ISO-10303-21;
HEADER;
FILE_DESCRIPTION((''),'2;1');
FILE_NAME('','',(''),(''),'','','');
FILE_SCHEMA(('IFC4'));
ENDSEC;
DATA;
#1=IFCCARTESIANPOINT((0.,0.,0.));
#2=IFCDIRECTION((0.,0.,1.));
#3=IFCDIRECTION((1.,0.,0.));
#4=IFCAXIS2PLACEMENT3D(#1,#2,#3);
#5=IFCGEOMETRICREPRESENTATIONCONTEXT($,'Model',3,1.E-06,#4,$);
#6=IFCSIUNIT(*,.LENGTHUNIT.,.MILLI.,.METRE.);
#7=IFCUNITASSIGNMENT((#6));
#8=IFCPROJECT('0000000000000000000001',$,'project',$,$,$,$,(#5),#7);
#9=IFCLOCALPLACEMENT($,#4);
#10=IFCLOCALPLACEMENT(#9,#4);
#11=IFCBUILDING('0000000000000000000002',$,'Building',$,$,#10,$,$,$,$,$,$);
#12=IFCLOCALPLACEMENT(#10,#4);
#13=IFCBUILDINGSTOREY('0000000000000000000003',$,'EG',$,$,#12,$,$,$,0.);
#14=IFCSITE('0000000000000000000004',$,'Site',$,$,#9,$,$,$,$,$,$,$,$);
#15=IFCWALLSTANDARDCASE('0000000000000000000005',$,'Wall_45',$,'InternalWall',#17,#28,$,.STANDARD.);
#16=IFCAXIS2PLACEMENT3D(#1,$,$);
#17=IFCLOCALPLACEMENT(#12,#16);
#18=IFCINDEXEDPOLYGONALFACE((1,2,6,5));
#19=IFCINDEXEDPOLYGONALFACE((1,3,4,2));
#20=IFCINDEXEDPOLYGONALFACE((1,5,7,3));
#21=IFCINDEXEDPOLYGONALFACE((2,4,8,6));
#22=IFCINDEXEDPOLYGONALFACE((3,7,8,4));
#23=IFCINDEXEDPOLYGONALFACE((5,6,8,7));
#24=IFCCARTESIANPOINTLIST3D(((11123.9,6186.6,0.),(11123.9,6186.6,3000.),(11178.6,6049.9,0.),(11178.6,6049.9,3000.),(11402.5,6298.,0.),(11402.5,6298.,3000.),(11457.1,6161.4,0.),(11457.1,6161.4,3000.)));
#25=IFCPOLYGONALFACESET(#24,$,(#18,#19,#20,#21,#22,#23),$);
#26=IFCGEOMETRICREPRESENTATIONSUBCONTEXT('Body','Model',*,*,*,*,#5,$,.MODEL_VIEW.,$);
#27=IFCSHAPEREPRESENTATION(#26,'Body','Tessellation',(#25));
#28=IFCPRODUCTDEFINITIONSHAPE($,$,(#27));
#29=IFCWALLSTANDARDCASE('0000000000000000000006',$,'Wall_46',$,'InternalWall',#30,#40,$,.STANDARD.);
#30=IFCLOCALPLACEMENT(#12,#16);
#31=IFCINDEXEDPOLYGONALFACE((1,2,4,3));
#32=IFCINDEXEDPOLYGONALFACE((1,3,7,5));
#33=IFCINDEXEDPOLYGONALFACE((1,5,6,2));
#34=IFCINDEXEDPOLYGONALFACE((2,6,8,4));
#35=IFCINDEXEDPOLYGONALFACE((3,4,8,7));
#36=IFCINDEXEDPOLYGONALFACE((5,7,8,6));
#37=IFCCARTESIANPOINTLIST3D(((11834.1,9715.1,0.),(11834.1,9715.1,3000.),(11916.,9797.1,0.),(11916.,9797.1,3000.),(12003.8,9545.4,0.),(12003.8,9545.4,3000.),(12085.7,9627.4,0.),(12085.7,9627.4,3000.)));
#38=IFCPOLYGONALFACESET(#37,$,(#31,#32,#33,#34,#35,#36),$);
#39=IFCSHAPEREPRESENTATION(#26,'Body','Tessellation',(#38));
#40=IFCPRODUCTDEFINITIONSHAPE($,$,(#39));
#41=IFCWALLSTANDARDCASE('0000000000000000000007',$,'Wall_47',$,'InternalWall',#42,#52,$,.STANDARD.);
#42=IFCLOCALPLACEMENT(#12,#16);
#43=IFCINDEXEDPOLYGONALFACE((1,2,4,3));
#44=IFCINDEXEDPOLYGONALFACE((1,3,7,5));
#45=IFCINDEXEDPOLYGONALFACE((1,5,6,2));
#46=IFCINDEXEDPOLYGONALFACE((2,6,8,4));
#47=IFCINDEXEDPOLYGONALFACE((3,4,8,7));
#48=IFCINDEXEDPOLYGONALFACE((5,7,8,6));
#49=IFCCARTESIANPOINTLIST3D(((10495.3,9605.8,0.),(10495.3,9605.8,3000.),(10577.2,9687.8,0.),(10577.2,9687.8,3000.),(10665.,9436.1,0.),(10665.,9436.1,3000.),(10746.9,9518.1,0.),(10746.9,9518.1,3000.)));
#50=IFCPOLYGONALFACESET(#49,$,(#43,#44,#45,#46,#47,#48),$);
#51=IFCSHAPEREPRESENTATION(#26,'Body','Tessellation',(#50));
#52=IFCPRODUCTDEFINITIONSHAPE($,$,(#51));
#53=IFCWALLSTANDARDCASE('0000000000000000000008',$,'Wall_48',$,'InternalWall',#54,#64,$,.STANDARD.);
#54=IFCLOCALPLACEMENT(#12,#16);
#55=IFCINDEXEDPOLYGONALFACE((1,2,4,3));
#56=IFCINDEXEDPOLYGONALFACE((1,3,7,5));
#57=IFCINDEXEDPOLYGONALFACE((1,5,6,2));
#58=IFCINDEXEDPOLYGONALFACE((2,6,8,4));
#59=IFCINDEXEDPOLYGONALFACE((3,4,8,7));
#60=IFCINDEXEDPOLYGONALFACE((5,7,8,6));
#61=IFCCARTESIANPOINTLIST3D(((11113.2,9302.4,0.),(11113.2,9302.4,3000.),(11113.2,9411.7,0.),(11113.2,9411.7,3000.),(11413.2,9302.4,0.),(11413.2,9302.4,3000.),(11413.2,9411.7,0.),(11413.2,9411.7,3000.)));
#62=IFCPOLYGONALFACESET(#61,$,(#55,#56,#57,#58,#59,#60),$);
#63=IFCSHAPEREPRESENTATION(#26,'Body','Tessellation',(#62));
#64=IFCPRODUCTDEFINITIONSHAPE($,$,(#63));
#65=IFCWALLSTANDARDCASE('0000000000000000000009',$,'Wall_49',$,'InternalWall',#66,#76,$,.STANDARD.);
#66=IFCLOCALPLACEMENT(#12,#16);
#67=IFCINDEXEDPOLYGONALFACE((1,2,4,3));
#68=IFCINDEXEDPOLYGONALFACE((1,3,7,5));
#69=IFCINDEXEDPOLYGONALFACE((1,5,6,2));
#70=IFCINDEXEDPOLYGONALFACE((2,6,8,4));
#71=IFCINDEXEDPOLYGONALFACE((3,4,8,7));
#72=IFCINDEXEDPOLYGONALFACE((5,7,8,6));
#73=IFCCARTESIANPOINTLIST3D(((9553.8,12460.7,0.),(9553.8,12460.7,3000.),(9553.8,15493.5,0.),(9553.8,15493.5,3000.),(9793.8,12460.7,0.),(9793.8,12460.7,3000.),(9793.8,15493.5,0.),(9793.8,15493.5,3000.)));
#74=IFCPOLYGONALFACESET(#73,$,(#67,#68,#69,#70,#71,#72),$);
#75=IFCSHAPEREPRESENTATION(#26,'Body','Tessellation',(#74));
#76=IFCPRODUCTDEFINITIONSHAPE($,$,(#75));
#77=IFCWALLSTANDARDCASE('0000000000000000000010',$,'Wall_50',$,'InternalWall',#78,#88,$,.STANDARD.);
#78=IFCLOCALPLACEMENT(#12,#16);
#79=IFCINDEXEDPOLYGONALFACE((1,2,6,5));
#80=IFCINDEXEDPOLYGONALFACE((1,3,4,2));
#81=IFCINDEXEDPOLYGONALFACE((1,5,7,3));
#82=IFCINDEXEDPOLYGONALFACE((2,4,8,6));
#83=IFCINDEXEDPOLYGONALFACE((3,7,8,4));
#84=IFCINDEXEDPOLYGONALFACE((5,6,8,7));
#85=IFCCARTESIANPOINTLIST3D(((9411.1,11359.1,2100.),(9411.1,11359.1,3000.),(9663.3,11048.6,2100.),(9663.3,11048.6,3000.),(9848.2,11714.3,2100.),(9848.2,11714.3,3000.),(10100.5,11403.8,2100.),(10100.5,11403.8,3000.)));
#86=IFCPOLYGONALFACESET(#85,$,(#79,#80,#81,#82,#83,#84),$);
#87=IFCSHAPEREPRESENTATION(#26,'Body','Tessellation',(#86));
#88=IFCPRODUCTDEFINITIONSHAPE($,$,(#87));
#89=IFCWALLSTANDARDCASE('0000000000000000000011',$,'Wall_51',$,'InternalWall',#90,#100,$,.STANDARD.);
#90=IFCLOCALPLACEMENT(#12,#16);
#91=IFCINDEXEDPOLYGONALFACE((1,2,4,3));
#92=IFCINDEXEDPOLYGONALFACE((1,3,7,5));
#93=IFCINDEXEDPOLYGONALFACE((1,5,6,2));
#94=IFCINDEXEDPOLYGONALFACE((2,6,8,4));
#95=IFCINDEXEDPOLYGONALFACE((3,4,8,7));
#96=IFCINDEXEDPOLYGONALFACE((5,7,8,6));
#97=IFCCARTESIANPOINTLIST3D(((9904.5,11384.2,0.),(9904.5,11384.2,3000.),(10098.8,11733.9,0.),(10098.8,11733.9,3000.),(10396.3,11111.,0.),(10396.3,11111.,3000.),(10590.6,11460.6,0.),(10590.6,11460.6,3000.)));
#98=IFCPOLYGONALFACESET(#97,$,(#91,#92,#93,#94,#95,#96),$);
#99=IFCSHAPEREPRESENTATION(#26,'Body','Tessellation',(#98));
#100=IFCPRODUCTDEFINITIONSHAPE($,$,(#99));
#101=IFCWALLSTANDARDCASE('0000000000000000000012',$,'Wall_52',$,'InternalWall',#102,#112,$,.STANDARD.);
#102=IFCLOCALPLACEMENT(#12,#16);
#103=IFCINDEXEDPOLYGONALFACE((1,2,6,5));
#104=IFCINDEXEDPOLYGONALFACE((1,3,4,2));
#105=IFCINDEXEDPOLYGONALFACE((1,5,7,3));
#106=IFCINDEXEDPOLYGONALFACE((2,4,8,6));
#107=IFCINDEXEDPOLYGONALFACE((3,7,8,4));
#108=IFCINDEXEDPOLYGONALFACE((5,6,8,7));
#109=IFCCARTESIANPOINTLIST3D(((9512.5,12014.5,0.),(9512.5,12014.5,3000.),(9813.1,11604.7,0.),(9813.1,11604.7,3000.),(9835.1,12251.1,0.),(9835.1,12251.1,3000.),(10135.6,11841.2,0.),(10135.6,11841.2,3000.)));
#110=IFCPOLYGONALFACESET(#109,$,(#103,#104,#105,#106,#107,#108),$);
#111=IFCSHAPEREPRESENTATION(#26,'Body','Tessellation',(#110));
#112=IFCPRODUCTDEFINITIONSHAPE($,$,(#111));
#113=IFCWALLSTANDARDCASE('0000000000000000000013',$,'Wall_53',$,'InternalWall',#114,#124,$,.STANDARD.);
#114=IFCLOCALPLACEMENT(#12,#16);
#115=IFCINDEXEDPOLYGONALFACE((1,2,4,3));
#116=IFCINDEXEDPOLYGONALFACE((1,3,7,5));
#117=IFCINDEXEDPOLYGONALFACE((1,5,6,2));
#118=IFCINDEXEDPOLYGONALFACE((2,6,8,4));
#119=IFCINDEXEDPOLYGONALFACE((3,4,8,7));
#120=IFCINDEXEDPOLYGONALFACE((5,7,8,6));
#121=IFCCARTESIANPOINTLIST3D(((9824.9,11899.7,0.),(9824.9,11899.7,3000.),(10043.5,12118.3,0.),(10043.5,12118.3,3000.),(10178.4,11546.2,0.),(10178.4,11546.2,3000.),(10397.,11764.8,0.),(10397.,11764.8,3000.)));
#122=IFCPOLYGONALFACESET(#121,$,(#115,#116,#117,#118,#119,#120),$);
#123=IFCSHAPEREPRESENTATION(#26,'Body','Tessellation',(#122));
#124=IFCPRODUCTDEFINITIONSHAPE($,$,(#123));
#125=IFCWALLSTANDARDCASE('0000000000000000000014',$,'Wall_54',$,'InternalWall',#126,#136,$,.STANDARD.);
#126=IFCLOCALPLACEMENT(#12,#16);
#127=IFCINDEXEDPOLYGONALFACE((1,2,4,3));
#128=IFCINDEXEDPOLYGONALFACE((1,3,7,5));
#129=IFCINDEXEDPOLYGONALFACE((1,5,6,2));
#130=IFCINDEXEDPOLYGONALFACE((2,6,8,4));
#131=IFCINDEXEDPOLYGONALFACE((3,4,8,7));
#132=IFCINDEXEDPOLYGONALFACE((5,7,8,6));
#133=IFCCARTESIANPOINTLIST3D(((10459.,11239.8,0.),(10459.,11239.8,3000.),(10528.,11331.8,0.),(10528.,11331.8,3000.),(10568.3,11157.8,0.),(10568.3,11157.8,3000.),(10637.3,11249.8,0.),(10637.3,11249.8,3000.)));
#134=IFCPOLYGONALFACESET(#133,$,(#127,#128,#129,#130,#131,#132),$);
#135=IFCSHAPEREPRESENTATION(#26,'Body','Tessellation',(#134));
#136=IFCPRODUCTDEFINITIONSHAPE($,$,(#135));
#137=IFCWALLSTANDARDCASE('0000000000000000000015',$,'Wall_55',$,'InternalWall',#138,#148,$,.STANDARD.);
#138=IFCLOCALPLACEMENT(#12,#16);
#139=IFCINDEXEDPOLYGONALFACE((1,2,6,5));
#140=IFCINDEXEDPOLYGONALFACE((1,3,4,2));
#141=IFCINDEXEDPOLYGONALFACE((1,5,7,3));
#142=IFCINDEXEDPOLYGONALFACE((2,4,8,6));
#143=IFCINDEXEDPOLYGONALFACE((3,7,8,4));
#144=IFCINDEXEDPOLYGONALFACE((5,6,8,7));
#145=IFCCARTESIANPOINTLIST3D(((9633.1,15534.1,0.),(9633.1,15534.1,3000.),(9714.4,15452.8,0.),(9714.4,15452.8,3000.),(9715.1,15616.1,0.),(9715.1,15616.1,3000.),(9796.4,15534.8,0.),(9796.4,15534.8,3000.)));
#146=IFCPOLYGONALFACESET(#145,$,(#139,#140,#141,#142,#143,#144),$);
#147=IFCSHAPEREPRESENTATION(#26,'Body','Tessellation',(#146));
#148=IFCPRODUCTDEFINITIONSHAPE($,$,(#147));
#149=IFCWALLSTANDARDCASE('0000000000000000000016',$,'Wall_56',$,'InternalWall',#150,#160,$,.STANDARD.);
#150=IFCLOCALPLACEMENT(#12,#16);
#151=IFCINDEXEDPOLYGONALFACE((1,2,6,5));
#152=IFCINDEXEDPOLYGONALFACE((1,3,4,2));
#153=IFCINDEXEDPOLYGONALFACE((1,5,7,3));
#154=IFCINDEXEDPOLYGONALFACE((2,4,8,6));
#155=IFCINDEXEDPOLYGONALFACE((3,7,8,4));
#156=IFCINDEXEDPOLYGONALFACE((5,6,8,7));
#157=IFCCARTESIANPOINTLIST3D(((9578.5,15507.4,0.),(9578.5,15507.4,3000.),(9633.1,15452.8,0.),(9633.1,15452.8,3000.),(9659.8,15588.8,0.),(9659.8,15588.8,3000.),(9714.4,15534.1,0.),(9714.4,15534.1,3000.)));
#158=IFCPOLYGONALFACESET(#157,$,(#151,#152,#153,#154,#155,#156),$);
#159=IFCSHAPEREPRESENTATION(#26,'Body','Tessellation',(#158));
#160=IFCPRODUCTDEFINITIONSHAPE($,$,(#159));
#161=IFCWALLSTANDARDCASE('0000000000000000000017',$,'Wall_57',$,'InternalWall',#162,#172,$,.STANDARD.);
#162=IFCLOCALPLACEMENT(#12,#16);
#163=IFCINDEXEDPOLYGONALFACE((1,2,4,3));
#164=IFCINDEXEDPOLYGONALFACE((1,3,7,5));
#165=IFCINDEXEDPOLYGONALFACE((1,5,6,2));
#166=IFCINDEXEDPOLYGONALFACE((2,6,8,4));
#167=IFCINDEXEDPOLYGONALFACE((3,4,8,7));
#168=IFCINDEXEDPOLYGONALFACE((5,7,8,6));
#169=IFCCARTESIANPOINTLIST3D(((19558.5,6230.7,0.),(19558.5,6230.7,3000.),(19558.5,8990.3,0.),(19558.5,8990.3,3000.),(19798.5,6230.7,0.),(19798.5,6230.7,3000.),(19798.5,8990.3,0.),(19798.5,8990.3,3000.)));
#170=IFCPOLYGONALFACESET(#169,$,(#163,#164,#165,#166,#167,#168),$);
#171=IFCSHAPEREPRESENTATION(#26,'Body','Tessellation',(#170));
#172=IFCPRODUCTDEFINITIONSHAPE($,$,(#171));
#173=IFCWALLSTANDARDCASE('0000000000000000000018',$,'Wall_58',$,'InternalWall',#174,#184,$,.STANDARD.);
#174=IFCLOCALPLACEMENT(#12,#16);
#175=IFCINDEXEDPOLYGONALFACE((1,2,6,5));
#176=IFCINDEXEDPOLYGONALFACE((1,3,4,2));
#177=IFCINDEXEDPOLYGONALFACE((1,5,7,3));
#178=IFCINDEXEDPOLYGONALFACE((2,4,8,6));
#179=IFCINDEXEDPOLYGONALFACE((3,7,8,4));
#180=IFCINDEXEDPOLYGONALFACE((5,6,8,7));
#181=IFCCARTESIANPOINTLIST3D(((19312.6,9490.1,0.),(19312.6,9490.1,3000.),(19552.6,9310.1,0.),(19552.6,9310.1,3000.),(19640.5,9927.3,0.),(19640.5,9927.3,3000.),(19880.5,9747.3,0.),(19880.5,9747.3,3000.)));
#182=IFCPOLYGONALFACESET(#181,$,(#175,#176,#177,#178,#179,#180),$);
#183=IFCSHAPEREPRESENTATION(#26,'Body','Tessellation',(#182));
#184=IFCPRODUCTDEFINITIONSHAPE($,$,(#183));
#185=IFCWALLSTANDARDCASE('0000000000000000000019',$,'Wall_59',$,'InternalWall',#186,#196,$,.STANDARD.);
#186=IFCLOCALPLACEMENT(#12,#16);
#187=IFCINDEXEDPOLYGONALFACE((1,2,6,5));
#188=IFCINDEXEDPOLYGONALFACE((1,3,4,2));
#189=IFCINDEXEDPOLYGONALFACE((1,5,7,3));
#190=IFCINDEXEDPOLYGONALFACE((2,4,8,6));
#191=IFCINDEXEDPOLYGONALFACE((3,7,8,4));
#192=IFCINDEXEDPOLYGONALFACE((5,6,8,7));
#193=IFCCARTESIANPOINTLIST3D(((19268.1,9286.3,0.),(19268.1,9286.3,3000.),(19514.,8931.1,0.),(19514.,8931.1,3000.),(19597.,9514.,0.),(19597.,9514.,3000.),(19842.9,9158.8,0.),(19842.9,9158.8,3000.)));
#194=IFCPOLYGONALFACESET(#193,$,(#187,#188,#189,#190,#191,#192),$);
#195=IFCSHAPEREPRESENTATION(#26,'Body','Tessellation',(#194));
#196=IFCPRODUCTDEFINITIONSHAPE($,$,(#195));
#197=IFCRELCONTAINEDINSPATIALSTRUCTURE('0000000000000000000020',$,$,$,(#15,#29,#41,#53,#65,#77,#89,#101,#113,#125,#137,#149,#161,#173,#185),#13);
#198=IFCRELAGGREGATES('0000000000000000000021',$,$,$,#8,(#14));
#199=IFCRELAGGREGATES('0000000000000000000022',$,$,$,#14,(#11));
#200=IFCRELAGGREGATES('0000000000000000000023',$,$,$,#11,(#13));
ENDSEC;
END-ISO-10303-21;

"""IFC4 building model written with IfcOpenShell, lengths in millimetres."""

from ifc_helpers import new_model, si_unit, frame, origin_with_axes, place, context, subcontext, project, spatial, rectangle, extrude, element, save


model = new_model("IFC4")

# Units and contexts
model_context = context("Model", 3, precision=1e-06, world=origin_with_axes())
body_context = subcontext(model_context, "Body", "Model", "MODEL_VIEW")
ifc_project = project(units=[si_unit("LENGTHUNIT", "METRE", prefix="MILLI")], contexts=[model_context])

# Site, building, storey
site_placement = place(None, origin_with_axes())
site = spatial("IfcSite", under=ifc_project, at=site_placement, Name="Site")
building_placement = place(site_placement, origin_with_axes())
building = spatial("IfcBuilding", under=site, at=building_placement, Name="Building")
storey_placement = place(building_placement, origin_with_axes())
storey = spatial("IfcBuildingStorey", under=building, at=storey_placement, Name="EG", Elevation=0.0)

# Walls
wall_1_placement = place(storey_placement, origin_with_axes())
element("IfcWallStandardCase", 1, at=wall_1_placement, inside=storey, Name="Wall_45", ObjectType="InternalWall", PredefinedType="STANDARD", context=body_context, shape_type="SweptSolid", body=[
    extrude(rectangle(XDim=147.1, YDim=300.0), frame((11290.5, 6174.0, 0.0), z_axis=(0.0, 0.0, 1.0), x_axis=(-0.371391, 0.928477, 0.0)), (0.0, 0.0, 1.0), 3000.0),
])
wall_2_placement = place(storey_placement, origin_with_axes())
element("IfcWallStandardCase", 2, at=wall_2_placement, inside=storey, Name="Wall_46", ObjectType="InternalWall", PredefinedType="STANDARD", context=body_context, shape_type="SweptSolid", body=[
    extrude(rectangle(XDim=115.9, YDim=240.0), frame((11959.9, 9671.2, 0.0), z_axis=(0.0, 0.0, 1.0), x_axis=(0.707107, 0.707107, 0.0)), (0.0, 0.0, 1.0), 3000.0),
])
wall_3_placement = place(storey_placement, origin_with_axes())
element("IfcWallStandardCase", 3, at=wall_3_placement, inside=storey, Name="Wall_47", ObjectType="InternalWall", PredefinedType="STANDARD", context=body_context, shape_type="SweptSolid", body=[
    extrude(rectangle(XDim=115.9, YDim=240.0), frame((10621.1, 9561.9, 0.0), z_axis=(0.0, 0.0, 1.0), x_axis=(-0.707107, -0.707107, 0.0)), (0.0, 0.0, 1.0), 3000.0),
])
wall_4_placement = place(storey_placement, origin_with_axes())
element("IfcWallStandardCase", 4, at=wall_4_placement, inside=storey, Name="Wall_48", ObjectType="InternalWall", PredefinedType="STANDARD", context=body_context, shape_type="SweptSolid", body=[
    extrude(rectangle(XDim=109.3, YDim=300.0), frame((11263.2, 9357.0, 0.0), z_axis=(0.0, 0.0, 1.0), x_axis=(0.0, 1.0, 0.0)), (0.0, 0.0, 1.0), 3000.0),
])
wall_5_placement = place(storey_placement, origin_with_axes())
element("IfcWallStandardCase", 5, at=wall_5_placement, inside=storey, Name="Wall_49", ObjectType="InternalWall", PredefinedType="STANDARD", context=body_context, shape_type="SweptSolid", body=[
    extrude(rectangle(XDim=3032.8, YDim=240.0), frame((9673.8, 13977.1, 0.0), z_axis=(0.0, 0.0, 1.0), x_axis=(0.0, 1.0, 0.0)), (0.0, 0.0, 1.0), 3000.0),
])

# Wall, opening
wall_6_placement = place(storey_placement, origin_with_axes())
wall_6 = element("IfcWallStandardCase", 6, at=wall_6_placement, inside=storey, Name="Wall_50", ObjectType="InternalWall", PredefinedType="STANDARD", context=body_context, shape_type="SweptSolid", body=[
    extrude(rectangle(XDim=563.3, YDim=400.0), frame((9755.8, 11381.4, 0.0), z_axis=(0.0, 0.0, 1.0), x_axis=(-0.776114, -0.630593, 0.0)), (0.0, 0.0, 1.0), 3000.0),
])
opening_1_placement = place(wall_6_placement, origin_with_axes())
element("IfcOpeningElement", 7, at=opening_1_placement, inside=storey, cuts=wall_6, context=body_context, shape_type="SweptSolid", body=[
    extrude(rectangle(XDim=1320.1, YDim=400.0), frame((9528.3, 11196.6, 0.0), z_axis=(0.0, 0.0, 1.0), x_axis=(-0.776114, -0.630593, 0.0)), (0.0, 0.0, 1.0), 2100.0),
])

# Walls
wall_7_placement = place(storey_placement, origin_with_axes())
element("IfcWallStandardCase", 8, at=wall_7_placement, inside=storey, Name="Wall_51", ObjectType="InternalWall", PredefinedType="STANDARD", context=body_context, shape_type="SweptSolid", body=[
    extrude(rectangle(XDim=562.6, YDim=400.0), frame((10247.6, 11422.4, 0.0), z_axis=(0.0, 0.0, 1.0), x_axis=(0.874157, -0.485643, 0.0)), (0.0, 0.0, 1.0), 3000.0),
])
wall_8_placement = place(storey_placement, origin_with_axes())
element("IfcWallStandardCase", 9, at=wall_8_placement, inside=storey, Name="Wall_52", ObjectType="InternalWall", PredefinedType="STANDARD", context=body_context, shape_type="SweptSolid", body=[
    extrude(rectangle(XDim=508.2, YDim=400.0), frame((9824.1, 11927.9, 0.0), z_axis=(0.0, 0.0, 1.0), x_axis=(-0.591364, 0.806405, 0.0)), (0.0, 0.0, 1.0), 3000.0),
])
wall_9_placement = place(storey_placement, origin_with_axes())
element("IfcWallStandardCase", 10, at=wall_9_placement, inside=storey, Name="Wall_53", ObjectType="InternalWall", PredefinedType="STANDARD", context=body_context, shape_type="SweptSolid", body=[
    extrude(rectangle(XDim=309.1, YDim=500.0), frame((10110.9, 11832.3, 0.0), z_axis=(0.0, 0.0, 1.0), x_axis=(0.707107, 0.707107, 0.0)), (0.0, 0.0, 1.0), 3000.0),
])
wall_10_placement = place(storey_placement, origin_with_axes())
element("IfcWallStandardCase", 11, at=wall_10_placement, inside=storey, Name="Wall_54", ObjectType="InternalWall", PredefinedType="STANDARD", context=body_context, shape_type="SweptSolid", body=[
    extrude(rectangle(XDim=136.6, YDim=115.0), frame((10548.1, 11244.8, 0.0), z_axis=(0.0, 0.0, 1.0), x_axis=(0.8, -0.6, 0.0)), (0.0, 0.0, 1.0), 3000.0),
])
wall_11_placement = place(storey_placement, origin_with_axes())
element("IfcWallStandardCase", 12, at=wall_11_placement, inside=storey, Name="Wall_55", ObjectType="InternalWall", PredefinedType="STANDARD", context=body_context, shape_type="SweptSolid", body=[
    extrude(rectangle(XDim=115.9, YDim=115.0), frame((9714.8, 15534.4, 0.0), z_axis=(0.0, 0.0, 1.0), x_axis=(0.707107, 0.707107, 0.0)), (0.0, 0.0, 1.0), 3000.0),
])
wall_12_placement = place(storey_placement, origin_with_axes())
element("IfcWallStandardCase", 13, at=wall_12_placement, inside=storey, Name="Wall_56", ObjectType="InternalWall", PredefinedType="STANDARD", context=body_context, shape_type="SweptSolid", body=[
    extrude(rectangle(XDim=77.3, YDim=115.0), frame((9646.5, 15520.8, 0.0), z_axis=(0.0, 0.0, 1.0), x_axis=(-0.707107, 0.707107, 0.0)), (0.0, 0.0, 1.0), 3000.0),
])
wall_13_placement = place(storey_placement, origin_with_axes())
element("IfcWallStandardCase", 14, at=wall_13_placement, inside=storey, Name="Wall_57", ObjectType="InternalWall", PredefinedType="STANDARD", context=body_context, shape_type="SweptSolid", body=[
    extrude(rectangle(XDim=2759.6, YDim=240.0), frame((19678.5, 7610.5, 0.0), z_axis=(0.0, 0.0, 1.0), x_axis=(0.0, -1.0, 0.0)), (0.0, 0.0, 1.0), 3000.0),
])
wall_14_placement = place(storey_placement, origin_with_axes())
element("IfcWallStandardCase", 15, at=wall_14_placement, inside=storey, Name="Wall_58", ObjectType="InternalWall", PredefinedType="STANDARD", context=body_context, shape_type="SweptSolid", body=[
    extrude(rectangle(XDim=546.4, YDim=300.0), frame((19596.5, 9618.7, 0.0), z_axis=(0.0, 0.0, 1.0), x_axis=(0.6, 0.8, 0.0)), (0.0, 0.0, 1.0), 3000.0),
])
wall_15_placement = place(storey_placement, origin_with_axes())
element("IfcWallStandardCase", 16, at=wall_15_placement, inside=storey, Name="Wall_59", ObjectType="InternalWall", PredefinedType="STANDARD", context=body_context, shape_type="SweptSolid", body=[
    extrude(rectangle(XDim=432.0, YDim=400.0), frame((19555.5, 9222.5, 0.0), z_axis=(0.0, 0.0, 1.0), x_axis=(-0.56921, 0.822192, 0.0)), (0.0, 0.0, 1.0), 3000.0),
])

save(model, "model.ifc")
